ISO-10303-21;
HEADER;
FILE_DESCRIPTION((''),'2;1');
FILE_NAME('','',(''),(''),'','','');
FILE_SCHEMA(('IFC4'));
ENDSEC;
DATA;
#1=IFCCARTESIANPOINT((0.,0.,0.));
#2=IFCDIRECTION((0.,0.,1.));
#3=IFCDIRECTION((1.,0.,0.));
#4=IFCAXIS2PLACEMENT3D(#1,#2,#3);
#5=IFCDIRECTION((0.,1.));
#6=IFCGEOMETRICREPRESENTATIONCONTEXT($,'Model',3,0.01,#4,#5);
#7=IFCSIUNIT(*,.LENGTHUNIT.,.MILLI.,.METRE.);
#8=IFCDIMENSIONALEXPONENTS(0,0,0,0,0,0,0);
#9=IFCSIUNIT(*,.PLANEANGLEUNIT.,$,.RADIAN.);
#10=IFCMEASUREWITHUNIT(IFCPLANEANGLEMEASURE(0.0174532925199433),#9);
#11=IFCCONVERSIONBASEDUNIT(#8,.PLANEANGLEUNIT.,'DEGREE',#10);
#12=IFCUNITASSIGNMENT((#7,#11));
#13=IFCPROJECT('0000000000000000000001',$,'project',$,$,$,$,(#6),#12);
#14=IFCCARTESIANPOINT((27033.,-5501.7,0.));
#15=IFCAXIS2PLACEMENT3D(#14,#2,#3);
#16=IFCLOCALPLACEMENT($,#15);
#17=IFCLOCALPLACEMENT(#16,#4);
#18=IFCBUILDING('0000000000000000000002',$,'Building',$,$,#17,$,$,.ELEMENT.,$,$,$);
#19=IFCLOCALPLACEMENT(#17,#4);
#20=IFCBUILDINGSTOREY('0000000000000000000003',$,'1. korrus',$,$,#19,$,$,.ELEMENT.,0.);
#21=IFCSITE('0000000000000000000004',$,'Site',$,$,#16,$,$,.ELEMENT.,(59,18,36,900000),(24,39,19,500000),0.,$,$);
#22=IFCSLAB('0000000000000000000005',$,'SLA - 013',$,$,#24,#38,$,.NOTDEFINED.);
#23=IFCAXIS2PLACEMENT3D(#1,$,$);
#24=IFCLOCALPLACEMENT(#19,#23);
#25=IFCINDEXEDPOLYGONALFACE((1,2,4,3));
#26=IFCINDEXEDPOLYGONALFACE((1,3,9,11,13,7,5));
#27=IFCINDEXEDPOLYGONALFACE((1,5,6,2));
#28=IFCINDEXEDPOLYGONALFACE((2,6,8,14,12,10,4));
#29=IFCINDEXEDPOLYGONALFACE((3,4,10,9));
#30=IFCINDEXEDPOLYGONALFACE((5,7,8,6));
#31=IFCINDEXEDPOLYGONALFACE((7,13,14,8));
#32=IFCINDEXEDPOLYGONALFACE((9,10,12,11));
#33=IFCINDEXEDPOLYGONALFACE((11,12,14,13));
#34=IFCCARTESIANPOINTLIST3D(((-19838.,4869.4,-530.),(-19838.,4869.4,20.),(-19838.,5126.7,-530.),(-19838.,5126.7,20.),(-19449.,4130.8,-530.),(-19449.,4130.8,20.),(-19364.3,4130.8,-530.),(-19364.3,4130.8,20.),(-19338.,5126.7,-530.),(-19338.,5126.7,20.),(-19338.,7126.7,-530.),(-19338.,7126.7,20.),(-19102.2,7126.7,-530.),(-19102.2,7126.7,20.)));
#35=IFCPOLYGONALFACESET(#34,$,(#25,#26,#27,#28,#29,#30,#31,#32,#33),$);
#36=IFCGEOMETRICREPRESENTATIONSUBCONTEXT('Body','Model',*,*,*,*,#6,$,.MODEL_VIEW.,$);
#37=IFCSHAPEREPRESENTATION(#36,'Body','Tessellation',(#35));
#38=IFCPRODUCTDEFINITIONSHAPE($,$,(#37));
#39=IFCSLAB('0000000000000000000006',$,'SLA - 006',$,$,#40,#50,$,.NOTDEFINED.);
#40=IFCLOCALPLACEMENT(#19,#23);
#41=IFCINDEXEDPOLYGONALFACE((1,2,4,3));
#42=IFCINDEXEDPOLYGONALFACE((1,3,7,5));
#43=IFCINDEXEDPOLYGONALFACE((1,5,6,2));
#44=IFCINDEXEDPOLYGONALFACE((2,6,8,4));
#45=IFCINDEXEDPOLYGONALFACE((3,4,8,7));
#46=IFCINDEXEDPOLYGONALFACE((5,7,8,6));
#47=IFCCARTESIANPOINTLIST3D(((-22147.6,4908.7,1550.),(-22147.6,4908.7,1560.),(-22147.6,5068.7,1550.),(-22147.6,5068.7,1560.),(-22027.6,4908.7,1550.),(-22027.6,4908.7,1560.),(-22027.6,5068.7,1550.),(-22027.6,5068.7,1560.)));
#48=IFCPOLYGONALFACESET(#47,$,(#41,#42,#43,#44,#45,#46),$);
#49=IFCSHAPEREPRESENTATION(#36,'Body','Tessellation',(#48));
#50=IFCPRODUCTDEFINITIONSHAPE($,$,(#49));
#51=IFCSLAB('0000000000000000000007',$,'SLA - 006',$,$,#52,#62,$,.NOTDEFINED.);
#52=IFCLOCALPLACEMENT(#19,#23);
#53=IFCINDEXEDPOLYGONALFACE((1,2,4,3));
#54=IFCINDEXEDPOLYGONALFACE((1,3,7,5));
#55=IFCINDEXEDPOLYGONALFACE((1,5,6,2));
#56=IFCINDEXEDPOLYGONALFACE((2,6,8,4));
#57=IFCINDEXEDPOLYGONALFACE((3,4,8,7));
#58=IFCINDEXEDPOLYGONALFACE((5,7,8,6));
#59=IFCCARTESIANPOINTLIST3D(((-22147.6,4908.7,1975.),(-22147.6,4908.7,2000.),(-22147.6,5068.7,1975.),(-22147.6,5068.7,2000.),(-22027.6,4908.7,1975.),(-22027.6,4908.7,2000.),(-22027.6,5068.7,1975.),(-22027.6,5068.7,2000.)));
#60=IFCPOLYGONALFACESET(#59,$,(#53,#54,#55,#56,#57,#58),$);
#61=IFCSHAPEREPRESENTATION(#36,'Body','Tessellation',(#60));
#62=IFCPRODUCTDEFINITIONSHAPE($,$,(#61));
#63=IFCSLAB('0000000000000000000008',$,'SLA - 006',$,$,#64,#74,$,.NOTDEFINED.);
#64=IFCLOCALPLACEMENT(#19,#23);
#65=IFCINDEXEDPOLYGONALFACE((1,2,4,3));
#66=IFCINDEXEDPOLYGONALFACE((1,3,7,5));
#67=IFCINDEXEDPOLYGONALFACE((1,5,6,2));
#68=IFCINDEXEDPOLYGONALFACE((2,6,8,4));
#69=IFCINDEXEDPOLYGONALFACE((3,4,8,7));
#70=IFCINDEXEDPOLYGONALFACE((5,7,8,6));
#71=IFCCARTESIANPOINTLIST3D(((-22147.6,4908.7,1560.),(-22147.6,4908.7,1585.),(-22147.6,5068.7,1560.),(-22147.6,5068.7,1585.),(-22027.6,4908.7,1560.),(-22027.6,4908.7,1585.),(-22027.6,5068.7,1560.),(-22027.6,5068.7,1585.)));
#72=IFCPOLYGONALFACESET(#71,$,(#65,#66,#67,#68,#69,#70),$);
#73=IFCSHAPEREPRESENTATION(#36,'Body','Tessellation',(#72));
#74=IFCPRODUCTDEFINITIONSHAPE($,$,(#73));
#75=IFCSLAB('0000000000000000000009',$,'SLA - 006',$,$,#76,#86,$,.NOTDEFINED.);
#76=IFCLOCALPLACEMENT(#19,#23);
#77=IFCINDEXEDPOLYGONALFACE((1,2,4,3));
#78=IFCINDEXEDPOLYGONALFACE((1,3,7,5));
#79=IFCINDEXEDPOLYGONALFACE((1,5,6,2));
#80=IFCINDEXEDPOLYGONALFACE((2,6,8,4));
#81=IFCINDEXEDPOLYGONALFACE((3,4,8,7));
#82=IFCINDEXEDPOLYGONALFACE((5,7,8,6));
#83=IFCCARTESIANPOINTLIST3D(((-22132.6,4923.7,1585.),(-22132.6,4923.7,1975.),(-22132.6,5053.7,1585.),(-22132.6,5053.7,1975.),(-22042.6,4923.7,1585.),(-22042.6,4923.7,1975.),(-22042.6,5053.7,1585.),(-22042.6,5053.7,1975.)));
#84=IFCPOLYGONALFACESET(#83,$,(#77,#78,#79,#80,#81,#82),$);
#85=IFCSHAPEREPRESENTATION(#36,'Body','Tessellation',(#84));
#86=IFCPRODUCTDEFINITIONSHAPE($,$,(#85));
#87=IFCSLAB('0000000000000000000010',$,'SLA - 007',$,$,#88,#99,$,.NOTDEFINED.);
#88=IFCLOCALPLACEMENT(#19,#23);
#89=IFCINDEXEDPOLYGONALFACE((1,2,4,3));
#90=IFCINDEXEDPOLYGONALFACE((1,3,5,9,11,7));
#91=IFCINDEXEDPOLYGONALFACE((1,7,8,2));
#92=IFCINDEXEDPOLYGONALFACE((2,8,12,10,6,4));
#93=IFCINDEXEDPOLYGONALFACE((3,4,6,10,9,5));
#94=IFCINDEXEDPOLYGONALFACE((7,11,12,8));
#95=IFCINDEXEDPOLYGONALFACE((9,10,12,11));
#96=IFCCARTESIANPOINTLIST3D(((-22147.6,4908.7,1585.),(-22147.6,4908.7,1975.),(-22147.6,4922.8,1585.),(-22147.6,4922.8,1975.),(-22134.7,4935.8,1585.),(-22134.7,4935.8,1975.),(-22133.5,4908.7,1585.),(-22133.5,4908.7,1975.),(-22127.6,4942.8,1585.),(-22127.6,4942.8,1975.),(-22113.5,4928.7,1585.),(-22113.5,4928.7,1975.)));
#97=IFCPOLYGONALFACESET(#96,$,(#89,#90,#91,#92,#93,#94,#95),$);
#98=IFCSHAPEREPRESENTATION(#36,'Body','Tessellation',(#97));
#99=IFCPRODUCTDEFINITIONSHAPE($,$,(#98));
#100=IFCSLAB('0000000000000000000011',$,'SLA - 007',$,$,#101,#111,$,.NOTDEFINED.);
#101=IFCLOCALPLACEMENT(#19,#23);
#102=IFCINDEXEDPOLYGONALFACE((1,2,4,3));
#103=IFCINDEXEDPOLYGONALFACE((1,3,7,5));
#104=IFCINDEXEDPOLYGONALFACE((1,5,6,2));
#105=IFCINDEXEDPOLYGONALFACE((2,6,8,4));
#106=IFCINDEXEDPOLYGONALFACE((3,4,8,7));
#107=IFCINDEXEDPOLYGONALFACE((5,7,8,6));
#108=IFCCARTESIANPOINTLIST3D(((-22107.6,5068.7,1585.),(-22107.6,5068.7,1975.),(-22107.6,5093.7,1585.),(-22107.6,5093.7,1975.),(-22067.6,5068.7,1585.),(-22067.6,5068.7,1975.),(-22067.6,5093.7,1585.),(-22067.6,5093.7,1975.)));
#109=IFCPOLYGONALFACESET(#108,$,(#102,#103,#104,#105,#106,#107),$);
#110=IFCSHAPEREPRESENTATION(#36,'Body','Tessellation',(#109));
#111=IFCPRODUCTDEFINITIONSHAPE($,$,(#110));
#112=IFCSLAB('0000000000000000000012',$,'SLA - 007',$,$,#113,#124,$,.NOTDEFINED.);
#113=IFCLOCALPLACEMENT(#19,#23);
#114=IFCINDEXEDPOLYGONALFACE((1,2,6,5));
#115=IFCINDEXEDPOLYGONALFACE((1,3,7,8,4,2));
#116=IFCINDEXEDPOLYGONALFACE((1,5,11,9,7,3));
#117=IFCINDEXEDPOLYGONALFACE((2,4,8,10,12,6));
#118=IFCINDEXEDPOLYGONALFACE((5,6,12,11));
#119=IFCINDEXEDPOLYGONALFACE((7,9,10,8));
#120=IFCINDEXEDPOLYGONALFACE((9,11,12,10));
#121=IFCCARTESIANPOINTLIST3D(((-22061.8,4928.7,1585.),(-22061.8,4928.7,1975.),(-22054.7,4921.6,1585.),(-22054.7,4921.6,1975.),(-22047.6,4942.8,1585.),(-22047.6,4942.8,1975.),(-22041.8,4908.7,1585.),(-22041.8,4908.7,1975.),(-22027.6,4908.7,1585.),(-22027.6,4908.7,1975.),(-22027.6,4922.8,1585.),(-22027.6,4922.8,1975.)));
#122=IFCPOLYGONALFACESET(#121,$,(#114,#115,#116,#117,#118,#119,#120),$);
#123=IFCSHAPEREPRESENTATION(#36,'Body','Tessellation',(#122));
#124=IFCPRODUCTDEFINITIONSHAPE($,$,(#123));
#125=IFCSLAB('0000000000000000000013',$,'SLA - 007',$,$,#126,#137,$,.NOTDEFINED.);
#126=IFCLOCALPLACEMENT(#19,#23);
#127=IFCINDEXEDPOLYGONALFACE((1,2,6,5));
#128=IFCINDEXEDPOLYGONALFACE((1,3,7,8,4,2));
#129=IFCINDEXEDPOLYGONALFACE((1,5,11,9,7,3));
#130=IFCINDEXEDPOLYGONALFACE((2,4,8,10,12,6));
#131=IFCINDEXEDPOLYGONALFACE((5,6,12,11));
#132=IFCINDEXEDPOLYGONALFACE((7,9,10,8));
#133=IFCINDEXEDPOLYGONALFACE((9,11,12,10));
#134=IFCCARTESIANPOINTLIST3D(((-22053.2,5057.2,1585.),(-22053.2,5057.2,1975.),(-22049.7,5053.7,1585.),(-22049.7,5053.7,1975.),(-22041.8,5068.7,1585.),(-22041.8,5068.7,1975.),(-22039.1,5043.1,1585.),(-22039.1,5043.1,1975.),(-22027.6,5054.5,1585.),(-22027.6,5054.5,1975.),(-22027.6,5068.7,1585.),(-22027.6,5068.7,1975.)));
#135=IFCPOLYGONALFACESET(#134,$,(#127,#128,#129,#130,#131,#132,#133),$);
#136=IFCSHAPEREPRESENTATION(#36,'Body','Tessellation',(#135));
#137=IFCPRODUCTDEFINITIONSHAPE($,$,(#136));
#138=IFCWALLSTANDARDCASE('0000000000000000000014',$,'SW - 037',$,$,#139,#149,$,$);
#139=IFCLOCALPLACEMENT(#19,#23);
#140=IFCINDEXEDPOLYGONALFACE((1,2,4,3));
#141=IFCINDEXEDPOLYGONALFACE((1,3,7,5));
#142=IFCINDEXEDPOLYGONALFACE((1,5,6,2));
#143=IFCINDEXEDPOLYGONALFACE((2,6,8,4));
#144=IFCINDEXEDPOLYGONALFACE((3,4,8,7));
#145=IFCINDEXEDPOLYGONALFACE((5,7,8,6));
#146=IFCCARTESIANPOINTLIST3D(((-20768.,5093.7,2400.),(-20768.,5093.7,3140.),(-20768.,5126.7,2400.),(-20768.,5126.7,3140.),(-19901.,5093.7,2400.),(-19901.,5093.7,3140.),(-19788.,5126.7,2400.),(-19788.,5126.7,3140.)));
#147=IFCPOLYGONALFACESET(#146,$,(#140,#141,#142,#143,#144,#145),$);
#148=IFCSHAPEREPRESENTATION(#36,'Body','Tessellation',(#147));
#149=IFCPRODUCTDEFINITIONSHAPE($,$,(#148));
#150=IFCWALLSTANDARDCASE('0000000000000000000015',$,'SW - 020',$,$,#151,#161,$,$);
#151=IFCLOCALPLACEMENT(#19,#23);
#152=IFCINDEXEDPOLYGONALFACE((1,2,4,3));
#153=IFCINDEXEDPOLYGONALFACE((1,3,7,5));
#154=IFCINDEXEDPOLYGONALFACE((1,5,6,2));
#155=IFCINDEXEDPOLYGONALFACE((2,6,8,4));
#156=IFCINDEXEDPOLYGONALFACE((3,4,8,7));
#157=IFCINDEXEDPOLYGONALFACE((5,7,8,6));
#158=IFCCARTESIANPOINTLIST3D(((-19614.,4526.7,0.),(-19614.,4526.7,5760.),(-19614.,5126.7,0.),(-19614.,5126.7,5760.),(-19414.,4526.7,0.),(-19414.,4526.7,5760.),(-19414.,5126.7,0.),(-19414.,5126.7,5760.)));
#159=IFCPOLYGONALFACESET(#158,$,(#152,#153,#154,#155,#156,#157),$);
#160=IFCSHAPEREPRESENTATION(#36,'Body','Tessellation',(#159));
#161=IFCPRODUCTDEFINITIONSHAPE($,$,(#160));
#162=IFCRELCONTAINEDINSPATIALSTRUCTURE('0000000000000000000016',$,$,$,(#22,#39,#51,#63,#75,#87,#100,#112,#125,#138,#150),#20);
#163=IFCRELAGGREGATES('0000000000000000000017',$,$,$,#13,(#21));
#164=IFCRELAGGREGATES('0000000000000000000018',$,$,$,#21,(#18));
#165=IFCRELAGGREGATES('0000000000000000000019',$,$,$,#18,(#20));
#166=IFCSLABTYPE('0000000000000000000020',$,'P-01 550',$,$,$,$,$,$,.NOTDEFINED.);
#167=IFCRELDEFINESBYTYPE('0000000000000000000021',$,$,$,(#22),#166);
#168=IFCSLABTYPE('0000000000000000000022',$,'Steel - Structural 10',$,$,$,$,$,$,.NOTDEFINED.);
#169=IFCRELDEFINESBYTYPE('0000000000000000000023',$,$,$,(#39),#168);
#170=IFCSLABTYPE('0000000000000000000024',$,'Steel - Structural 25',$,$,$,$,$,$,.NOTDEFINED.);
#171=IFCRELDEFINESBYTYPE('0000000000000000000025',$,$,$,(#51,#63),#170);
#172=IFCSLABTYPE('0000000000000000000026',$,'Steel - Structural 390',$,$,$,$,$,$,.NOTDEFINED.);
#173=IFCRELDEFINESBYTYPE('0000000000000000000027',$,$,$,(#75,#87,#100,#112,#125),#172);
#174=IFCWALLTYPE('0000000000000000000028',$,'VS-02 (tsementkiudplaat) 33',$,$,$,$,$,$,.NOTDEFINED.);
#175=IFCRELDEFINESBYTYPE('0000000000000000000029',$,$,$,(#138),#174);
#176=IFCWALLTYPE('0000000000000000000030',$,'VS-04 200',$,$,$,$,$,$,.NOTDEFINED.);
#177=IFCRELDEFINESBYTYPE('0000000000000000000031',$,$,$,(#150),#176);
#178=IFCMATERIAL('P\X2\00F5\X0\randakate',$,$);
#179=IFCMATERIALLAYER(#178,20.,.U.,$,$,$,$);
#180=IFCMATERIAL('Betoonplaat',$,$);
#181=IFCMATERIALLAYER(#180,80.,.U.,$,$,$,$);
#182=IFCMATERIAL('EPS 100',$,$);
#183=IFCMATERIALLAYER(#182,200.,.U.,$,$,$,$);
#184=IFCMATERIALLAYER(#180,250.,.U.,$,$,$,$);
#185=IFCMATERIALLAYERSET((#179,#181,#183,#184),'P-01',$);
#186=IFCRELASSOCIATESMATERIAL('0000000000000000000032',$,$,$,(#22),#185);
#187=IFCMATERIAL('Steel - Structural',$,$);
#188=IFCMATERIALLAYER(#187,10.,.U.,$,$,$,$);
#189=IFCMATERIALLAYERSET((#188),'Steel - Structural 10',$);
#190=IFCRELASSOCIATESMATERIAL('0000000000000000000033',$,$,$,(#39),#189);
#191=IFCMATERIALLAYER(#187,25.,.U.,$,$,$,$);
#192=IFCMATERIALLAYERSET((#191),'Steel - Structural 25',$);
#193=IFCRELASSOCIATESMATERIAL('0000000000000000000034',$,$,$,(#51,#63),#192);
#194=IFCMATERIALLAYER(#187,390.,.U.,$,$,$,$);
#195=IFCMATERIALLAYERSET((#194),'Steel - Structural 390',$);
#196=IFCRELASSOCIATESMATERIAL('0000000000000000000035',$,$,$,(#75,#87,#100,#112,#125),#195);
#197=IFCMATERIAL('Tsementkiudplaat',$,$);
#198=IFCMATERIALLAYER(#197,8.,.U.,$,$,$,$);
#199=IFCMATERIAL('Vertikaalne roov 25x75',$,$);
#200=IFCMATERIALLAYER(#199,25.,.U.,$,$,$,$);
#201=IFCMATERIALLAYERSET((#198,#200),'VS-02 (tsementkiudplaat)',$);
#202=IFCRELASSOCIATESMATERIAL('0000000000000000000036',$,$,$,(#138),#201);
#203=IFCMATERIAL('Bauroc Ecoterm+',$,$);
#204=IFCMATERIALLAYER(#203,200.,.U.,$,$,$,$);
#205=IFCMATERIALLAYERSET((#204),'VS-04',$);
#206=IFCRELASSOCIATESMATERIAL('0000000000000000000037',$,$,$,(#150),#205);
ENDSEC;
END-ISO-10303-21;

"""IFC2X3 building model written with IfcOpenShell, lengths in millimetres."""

from ifc_helpers import new_model, entity, si_unit, converted_unit, direction, frame, origin_with_axes, origin_2d_with_axis, place, context, subcontext, project, spatial, polyline, rectangle, outline, extrude, material, layer, layer_set, layer_usage, type_object, element, save


model = new_model("IFC2X3")

# Units and contexts
model_context = context("Model", 3, precision=0.01, world=origin_with_axes(), true_north=direction((0.0, 1.0)))
body_context = subcontext(model_context, "Body", "Model", "MODEL_VIEW")
ifc_project = project(units=[si_unit("LENGTHUNIT", "METRE", prefix="MILLI"), converted_unit("PLANEANGLEUNIT", "DEGREE", entity("IfcPlaneAngleMeasure", 0.0174532925199433), si_unit("PLANEANGLEUNIT", "RADIAN"), dimensions=[0, 0, 0, 0, 0, 0, 0])], contexts=[model_context])

# Site, building, storey
site_placement = place(None, frame((27033.0, -5501.7, 0.0), z_axis=(0.0, 0.0, 1.0), x_axis=(1.0, 0.0, 0.0)))
site = spatial("IfcSite", under=ifc_project, at=site_placement, Name="Site", CompositionType="ELEMENT", RefLatitude=(59, 18, 36, 900000), RefLongitude=(24, 39, 19, 500000), RefElevation=0.0)
building_placement = place(site_placement, origin_with_axes())
building = spatial("IfcBuilding", under=site, at=building_placement, Name="Building", CompositionType="ELEMENT")
storey_placement = place(building_placement, origin_with_axes())
storey = spatial("IfcBuildingStorey", under=building, at=storey_placement, Name="1. korrus", CompositionType="ELEMENT", Elevation=0.0)

# Slabs
ifc_material_1 = material(Name="Põrandakate")
ifc_layer_1 = layer(ifc_material_1, 20.0, ventilated="UNKNOWN")
ifc_material_2 = material(Name="Betoonplaat")
ifc_layer_2 = layer(ifc_material_2, 80.0, ventilated="UNKNOWN")
ifc_material_3 = material(Name="EPS 100")
ifc_layer_3 = layer(ifc_material_3, 200.0, ventilated="UNKNOWN")
ifc_layer_4 = layer(ifc_material_2, 250.0, ventilated="UNKNOWN")
ifc_layer_set_1 = layer_set([ifc_layer_1, ifc_layer_2, ifc_layer_3, ifc_layer_4], Name="P-01")
ifc_layer_usage_1 = layer_usage(ifc_layer_set_1, "AXIS3", "NEGATIVE", 550.0)
slab_type_1 = type_object("IfcSlabType", Name="P-01 550", PredefinedType="NOTDEFINED")
slab_1_placement = place(storey_placement, frame((-19838.0, 4869.4, 0.0), z_axis=(0.0, 0.0, 1.0), x_axis=(1.0, 0.0, 0.0)))
element("IfcSlab", 1, at=slab_1_placement, inside=storey, type_object=slab_type_1, material=ifc_layer_usage_1, Name="SLA - 013", PredefinedType="NOTDEFINED", context=body_context, shape_type="SweptSolid", body=[
    extrude(outline(polyline([(0.0, 0.0), (389.0, -738.6), (473.7, -738.6), (735.8, 2257.3), (500.0, 2257.3), (500.0, 257.3), (0.0, 257.3), (0.0, 0.0)])), frame((0.0, 0.0, -530.0), z_axis=(0.0, 0.0, 1.0), x_axis=(1.0, 0.0, 0.0)), (0.0, 0.0, 1.0), 550.0),
])
ifc_material_4 = material(Name="Steel - Structural")
ifc_layer_5 = layer(ifc_material_4, 10.0, ventilated="UNKNOWN")
ifc_layer_set_2 = layer_set([ifc_layer_5], Name="Steel - Structural 10")
ifc_layer_usage_2 = layer_usage(ifc_layer_set_2, "AXIS3", "NEGATIVE", 10.0)
slab_type_2 = type_object("IfcSlabType", Name="Steel - Structural 10", PredefinedType="NOTDEFINED")
slab_2_placement = place(storey_placement, frame((-22027.6, 5068.7, 1550.0), z_axis=(0.0, 0.0, 1.0), x_axis=(1.0, 0.0, 0.0)))
element("IfcSlab", 2, at=slab_2_placement, inside=storey, type_object=slab_type_2, material=ifc_layer_usage_2, Name="SLA - 006", PredefinedType="NOTDEFINED", context=body_context, shape_type="SweptSolid", body=[
    extrude(outline(polyline([(0.0, 0.0), (-120.0, 0.0), (-120.0, -160.0), (0.0, -160.0), (0.0, 0.0)])), origin_with_axes(), (0.0, 0.0, 1.0), 10.0),
])
ifc_layer_6 = layer(ifc_material_4, 25.0, ventilated="UNKNOWN")
ifc_layer_set_3 = layer_set([ifc_layer_6], Name="Steel - Structural 25")
ifc_layer_usage_3 = layer_usage(ifc_layer_set_3, "AXIS3", "NEGATIVE", 25.0)
slab_type_3 = type_object("IfcSlabType", Name="Steel - Structural 25", PredefinedType="NOTDEFINED")
slab_3_placement = place(storey_placement, frame((-22027.6, 5068.7, 2000.0), z_axis=(0.0, 0.0, 1.0), x_axis=(1.0, 0.0, 0.0)))
element("IfcSlab", 3, at=slab_3_placement, inside=storey, type_object=slab_type_3, material=ifc_layer_usage_3, Name="SLA - 006", PredefinedType="NOTDEFINED", context=body_context, shape_type="SweptSolid", body=[
    extrude(outline(polyline([(0.0, 0.0), (-120.0, 0.0), (-120.0, -160.0), (0.0, -160.0), (0.0, 0.0)])), frame((0.0, 0.0, -25.0), z_axis=(0.0, 0.0, 1.0), x_axis=(1.0, 0.0, 0.0)), (0.0, 0.0, 1.0), 25.0),
])
ifc_layer_usage_4 = layer_usage(ifc_layer_set_3, "AXIS3", "NEGATIVE", 25.0)
slab_4_placement = place(storey_placement, frame((-22027.6, 5068.7, 1560.0), z_axis=(0.0, 0.0, 1.0), x_axis=(1.0, 0.0, 0.0)))
element("IfcSlab", 4, at=slab_4_placement, inside=storey, type_object=slab_type_3, material=ifc_layer_usage_4, Name="SLA - 006", PredefinedType="NOTDEFINED", context=body_context, shape_type="SweptSolid", body=[
    extrude(outline(polyline([(0.0, 0.0), (-120.0, 0.0), (-120.0, -160.0), (0.0, -160.0), (0.0, 0.0)])), origin_with_axes(), (0.0, 0.0, 1.0), 25.0),
])
ifc_layer_7 = layer(ifc_material_4, 390.0, ventilated="UNKNOWN")
ifc_layer_set_4 = layer_set([ifc_layer_7], Name="Steel - Structural 390")
ifc_layer_usage_5 = layer_usage(ifc_layer_set_4, "AXIS3", "NEGATIVE", 390.0)
slab_type_4 = type_object("IfcSlabType", Name="Steel - Structural 390", PredefinedType="NOTDEFINED")
slab_5_placement = place(storey_placement, frame((-22042.6, 5053.7, 1585.0), z_axis=(0.0, 0.0, 1.0), x_axis=(1.0, 0.0, 0.0)))
element("IfcSlab", 5, at=slab_5_placement, inside=storey, type_object=slab_type_4, material=ifc_layer_usage_5, Name="SLA - 006", PredefinedType="NOTDEFINED", context=body_context, shape_type="SweptSolid", body=[
    extrude(outline(polyline([(0.0, 0.0), (-90.0, 0.0), (-90.0, -130.0), (0.0, -130.0), (0.0, 0.0)])), origin_with_axes(), (0.0, 0.0, 1.0), 390.0),
])
ifc_layer_usage_6 = layer_usage(ifc_layer_set_4, "AXIS3", "NEGATIVE", 390.0)
slab_6_placement = place(storey_placement, frame((-22134.7, 4935.8, 1585.0), z_axis=(0.0, 0.0, 1.0), x_axis=(1.0, 0.0, 0.0)))
element("IfcSlab", 6, at=slab_6_placement, inside=storey, type_object=slab_type_4, material=ifc_layer_usage_6, Name="SLA - 007", PredefinedType="NOTDEFINED", context=body_context, shape_type="SweptSolid", body=[
    extrude(outline(polyline([(0.0, 0.0), (-12.9, -12.9), (-12.9, -27.1), (1.2, -27.1), (21.2, -7.1), (7.1, 7.1), (0.0, 0.0)])), origin_with_axes(), (0.0, 0.0, 1.0), 390.0),
])
ifc_layer_usage_7 = layer_usage(ifc_layer_set_4, "AXIS3", "NEGATIVE", 390.0)
slab_7_placement = place(storey_placement, frame((-22107.6, 5068.7, 1585.0), z_axis=(0.0, 0.0, 1.0), x_axis=(1.0, 0.0, 0.0)))
element("IfcSlab", 7, at=slab_7_placement, inside=storey, type_object=slab_type_4, material=ifc_layer_usage_7, Name="SLA - 007", PredefinedType="NOTDEFINED", context=body_context, shape_type="SweptSolid", body=[
    extrude(outline(polyline([(0.0, 0.0), (40.0, 0.0), (40.0, 25.0), (0.0, 25.0), (0.0, 0.0)])), origin_with_axes(), (0.0, 0.0, 1.0), 390.0),
])
ifc_layer_usage_8 = layer_usage(ifc_layer_set_4, "AXIS3", "NEGATIVE", 390.0)
slab_8_placement = place(storey_placement, frame((-22054.7, 4921.6, 1585.0), z_axis=(0.0, 0.0, 1.0), x_axis=(1.0, 0.0, 0.0)))
element("IfcSlab", 8, at=slab_8_placement, inside=storey, type_object=slab_type_4, material=ifc_layer_usage_8, Name="SLA - 007", PredefinedType="NOTDEFINED", context=body_context, shape_type="SweptSolid", body=[
    extrude(outline(polyline([(0.0, 0.0), (12.9, -12.9), (27.1, -12.9), (27.1, 1.2), (7.1, 21.2), (-7.1, 7.1), (0.0, 0.0)])), origin_with_axes(), (0.0, 0.0, 1.0), 390.0),
])
ifc_layer_usage_9 = layer_usage(ifc_layer_set_4, "AXIS3", "NEGATIVE", 390.0)
slab_9_placement = place(storey_placement, frame((-22041.8, 5068.7, 1585.0), z_axis=(0.0, 0.0, 1.0), x_axis=(1.0, 0.0, 0.0)))
element("IfcSlab", 9, at=slab_9_placement, inside=storey, type_object=slab_type_4, material=ifc_layer_usage_9, Name="SLA - 007", PredefinedType="NOTDEFINED", context=body_context, shape_type="SweptSolid", body=[
    extrude(outline(polyline([(0.0, 0.0), (-11.5, -11.5), (-7.9, -15.0), (2.7, -25.6), (14.1, -14.1), (14.1, 0.0), (0.0, 0.0)])), origin_with_axes(), (0.0, 0.0, 1.0), 390.0),
])

# Shared definitions
ifc_material_5 = material(Name="Tsementkiudplaat")
ifc_layer_8 = layer(ifc_material_5, 8.0, ventilated="UNKNOWN")
ifc_material_6 = material(Name="Vertikaalne roov 25x75")
ifc_layer_9 = layer(ifc_material_6, 25.0, ventilated="UNKNOWN")
ifc_layer_set_5 = layer_set([ifc_layer_8, ifc_layer_9], Name="VS-02 (tsementkiudplaat)")
wall_type_1 = type_object("IfcWallType", Name="VS-02 (tsementkiudplaat) 33", PredefinedType="NOTDEFINED")

# Wall, opening
ifc_layer_usage_10 = layer_usage(ifc_layer_set_5, "AXIS2", "NEGATIVE", 33.0)
wall_1_placement = place(storey_placement, frame((-19901.0, 5126.7, 2400.0), z_axis=(0.0, 0.0, 1.0), x_axis=(-1.0, -0.000003, 0.0)))
wall_1 = element("IfcWallStandardCase", 10, at=wall_1_placement, inside=storey, type_object=wall_type_1, material=ifc_layer_usage_10, Name="SW - 037", context=body_context, shape_type="SweptSolid", body=[
    extrude(outline(polyline([(-113.0, 0.0), (867.0, 0.0), (867.0, 33.0), (0.0, 33.0), (-113.0, 0.0)])), origin_with_axes(), (0.0, 0.0, 1.0), 740.0),
])
opening_1_placement = place(wall_1_placement, frame((441.0, 0.0, -2400.0), z_axis=(0.0, 0.0, 1.0), x_axis=(1.0, 0.0, 0.0)))
element("IfcOpeningElement", 11, at=opening_1_placement, cuts=wall_1, context=body_context, shape_type="SweptSolid", body=[
    extrude(rectangle(XDim=882.0, YDim=2400.0, at=origin_2d_with_axis()), frame((0.0, -33.0, 1200.0), z_axis=(0.0, 1.0, 0.0), x_axis=(-1.0, 0.0, 0.0)), (0.0, 0.0, 1.0), 99.0),
])

# Wall
ifc_material_7 = material(Name="Bauroc Ecoterm+")
ifc_layer_10 = layer(ifc_material_7, 200.0, ventilated="UNKNOWN")
ifc_layer_set_6 = layer_set([ifc_layer_10], Name="VS-04")
ifc_layer_usage_11 = layer_usage(ifc_layer_set_6, "AXIS2", "POSITIVE", 0.0)
wall_type_2 = type_object("IfcWallType", Name="VS-04 200", PredefinedType="NOTDEFINED")
wall_2_placement = place(storey_placement, frame((-19614.0, 5126.7, 0.0), z_axis=(0.0, 0.0, 1.0), x_axis=(0.0, -1.0, 0.0)))
element("IfcWallStandardCase", 12, at=wall_2_placement, inside=storey, type_object=wall_type_2, material=ifc_layer_usage_11, Name="SW - 020", context=body_context, shape_type="SweptSolid", body=[
    extrude(outline(polyline([(0.0, 0.0), (600.0, 0.0), (600.0, 200.0), (0.0, 200.0), (0.0, 0.0)])), origin_with_axes(), (0.0, 0.0, 1.0), 5760.0),
])

save(model, "model.ifc")
